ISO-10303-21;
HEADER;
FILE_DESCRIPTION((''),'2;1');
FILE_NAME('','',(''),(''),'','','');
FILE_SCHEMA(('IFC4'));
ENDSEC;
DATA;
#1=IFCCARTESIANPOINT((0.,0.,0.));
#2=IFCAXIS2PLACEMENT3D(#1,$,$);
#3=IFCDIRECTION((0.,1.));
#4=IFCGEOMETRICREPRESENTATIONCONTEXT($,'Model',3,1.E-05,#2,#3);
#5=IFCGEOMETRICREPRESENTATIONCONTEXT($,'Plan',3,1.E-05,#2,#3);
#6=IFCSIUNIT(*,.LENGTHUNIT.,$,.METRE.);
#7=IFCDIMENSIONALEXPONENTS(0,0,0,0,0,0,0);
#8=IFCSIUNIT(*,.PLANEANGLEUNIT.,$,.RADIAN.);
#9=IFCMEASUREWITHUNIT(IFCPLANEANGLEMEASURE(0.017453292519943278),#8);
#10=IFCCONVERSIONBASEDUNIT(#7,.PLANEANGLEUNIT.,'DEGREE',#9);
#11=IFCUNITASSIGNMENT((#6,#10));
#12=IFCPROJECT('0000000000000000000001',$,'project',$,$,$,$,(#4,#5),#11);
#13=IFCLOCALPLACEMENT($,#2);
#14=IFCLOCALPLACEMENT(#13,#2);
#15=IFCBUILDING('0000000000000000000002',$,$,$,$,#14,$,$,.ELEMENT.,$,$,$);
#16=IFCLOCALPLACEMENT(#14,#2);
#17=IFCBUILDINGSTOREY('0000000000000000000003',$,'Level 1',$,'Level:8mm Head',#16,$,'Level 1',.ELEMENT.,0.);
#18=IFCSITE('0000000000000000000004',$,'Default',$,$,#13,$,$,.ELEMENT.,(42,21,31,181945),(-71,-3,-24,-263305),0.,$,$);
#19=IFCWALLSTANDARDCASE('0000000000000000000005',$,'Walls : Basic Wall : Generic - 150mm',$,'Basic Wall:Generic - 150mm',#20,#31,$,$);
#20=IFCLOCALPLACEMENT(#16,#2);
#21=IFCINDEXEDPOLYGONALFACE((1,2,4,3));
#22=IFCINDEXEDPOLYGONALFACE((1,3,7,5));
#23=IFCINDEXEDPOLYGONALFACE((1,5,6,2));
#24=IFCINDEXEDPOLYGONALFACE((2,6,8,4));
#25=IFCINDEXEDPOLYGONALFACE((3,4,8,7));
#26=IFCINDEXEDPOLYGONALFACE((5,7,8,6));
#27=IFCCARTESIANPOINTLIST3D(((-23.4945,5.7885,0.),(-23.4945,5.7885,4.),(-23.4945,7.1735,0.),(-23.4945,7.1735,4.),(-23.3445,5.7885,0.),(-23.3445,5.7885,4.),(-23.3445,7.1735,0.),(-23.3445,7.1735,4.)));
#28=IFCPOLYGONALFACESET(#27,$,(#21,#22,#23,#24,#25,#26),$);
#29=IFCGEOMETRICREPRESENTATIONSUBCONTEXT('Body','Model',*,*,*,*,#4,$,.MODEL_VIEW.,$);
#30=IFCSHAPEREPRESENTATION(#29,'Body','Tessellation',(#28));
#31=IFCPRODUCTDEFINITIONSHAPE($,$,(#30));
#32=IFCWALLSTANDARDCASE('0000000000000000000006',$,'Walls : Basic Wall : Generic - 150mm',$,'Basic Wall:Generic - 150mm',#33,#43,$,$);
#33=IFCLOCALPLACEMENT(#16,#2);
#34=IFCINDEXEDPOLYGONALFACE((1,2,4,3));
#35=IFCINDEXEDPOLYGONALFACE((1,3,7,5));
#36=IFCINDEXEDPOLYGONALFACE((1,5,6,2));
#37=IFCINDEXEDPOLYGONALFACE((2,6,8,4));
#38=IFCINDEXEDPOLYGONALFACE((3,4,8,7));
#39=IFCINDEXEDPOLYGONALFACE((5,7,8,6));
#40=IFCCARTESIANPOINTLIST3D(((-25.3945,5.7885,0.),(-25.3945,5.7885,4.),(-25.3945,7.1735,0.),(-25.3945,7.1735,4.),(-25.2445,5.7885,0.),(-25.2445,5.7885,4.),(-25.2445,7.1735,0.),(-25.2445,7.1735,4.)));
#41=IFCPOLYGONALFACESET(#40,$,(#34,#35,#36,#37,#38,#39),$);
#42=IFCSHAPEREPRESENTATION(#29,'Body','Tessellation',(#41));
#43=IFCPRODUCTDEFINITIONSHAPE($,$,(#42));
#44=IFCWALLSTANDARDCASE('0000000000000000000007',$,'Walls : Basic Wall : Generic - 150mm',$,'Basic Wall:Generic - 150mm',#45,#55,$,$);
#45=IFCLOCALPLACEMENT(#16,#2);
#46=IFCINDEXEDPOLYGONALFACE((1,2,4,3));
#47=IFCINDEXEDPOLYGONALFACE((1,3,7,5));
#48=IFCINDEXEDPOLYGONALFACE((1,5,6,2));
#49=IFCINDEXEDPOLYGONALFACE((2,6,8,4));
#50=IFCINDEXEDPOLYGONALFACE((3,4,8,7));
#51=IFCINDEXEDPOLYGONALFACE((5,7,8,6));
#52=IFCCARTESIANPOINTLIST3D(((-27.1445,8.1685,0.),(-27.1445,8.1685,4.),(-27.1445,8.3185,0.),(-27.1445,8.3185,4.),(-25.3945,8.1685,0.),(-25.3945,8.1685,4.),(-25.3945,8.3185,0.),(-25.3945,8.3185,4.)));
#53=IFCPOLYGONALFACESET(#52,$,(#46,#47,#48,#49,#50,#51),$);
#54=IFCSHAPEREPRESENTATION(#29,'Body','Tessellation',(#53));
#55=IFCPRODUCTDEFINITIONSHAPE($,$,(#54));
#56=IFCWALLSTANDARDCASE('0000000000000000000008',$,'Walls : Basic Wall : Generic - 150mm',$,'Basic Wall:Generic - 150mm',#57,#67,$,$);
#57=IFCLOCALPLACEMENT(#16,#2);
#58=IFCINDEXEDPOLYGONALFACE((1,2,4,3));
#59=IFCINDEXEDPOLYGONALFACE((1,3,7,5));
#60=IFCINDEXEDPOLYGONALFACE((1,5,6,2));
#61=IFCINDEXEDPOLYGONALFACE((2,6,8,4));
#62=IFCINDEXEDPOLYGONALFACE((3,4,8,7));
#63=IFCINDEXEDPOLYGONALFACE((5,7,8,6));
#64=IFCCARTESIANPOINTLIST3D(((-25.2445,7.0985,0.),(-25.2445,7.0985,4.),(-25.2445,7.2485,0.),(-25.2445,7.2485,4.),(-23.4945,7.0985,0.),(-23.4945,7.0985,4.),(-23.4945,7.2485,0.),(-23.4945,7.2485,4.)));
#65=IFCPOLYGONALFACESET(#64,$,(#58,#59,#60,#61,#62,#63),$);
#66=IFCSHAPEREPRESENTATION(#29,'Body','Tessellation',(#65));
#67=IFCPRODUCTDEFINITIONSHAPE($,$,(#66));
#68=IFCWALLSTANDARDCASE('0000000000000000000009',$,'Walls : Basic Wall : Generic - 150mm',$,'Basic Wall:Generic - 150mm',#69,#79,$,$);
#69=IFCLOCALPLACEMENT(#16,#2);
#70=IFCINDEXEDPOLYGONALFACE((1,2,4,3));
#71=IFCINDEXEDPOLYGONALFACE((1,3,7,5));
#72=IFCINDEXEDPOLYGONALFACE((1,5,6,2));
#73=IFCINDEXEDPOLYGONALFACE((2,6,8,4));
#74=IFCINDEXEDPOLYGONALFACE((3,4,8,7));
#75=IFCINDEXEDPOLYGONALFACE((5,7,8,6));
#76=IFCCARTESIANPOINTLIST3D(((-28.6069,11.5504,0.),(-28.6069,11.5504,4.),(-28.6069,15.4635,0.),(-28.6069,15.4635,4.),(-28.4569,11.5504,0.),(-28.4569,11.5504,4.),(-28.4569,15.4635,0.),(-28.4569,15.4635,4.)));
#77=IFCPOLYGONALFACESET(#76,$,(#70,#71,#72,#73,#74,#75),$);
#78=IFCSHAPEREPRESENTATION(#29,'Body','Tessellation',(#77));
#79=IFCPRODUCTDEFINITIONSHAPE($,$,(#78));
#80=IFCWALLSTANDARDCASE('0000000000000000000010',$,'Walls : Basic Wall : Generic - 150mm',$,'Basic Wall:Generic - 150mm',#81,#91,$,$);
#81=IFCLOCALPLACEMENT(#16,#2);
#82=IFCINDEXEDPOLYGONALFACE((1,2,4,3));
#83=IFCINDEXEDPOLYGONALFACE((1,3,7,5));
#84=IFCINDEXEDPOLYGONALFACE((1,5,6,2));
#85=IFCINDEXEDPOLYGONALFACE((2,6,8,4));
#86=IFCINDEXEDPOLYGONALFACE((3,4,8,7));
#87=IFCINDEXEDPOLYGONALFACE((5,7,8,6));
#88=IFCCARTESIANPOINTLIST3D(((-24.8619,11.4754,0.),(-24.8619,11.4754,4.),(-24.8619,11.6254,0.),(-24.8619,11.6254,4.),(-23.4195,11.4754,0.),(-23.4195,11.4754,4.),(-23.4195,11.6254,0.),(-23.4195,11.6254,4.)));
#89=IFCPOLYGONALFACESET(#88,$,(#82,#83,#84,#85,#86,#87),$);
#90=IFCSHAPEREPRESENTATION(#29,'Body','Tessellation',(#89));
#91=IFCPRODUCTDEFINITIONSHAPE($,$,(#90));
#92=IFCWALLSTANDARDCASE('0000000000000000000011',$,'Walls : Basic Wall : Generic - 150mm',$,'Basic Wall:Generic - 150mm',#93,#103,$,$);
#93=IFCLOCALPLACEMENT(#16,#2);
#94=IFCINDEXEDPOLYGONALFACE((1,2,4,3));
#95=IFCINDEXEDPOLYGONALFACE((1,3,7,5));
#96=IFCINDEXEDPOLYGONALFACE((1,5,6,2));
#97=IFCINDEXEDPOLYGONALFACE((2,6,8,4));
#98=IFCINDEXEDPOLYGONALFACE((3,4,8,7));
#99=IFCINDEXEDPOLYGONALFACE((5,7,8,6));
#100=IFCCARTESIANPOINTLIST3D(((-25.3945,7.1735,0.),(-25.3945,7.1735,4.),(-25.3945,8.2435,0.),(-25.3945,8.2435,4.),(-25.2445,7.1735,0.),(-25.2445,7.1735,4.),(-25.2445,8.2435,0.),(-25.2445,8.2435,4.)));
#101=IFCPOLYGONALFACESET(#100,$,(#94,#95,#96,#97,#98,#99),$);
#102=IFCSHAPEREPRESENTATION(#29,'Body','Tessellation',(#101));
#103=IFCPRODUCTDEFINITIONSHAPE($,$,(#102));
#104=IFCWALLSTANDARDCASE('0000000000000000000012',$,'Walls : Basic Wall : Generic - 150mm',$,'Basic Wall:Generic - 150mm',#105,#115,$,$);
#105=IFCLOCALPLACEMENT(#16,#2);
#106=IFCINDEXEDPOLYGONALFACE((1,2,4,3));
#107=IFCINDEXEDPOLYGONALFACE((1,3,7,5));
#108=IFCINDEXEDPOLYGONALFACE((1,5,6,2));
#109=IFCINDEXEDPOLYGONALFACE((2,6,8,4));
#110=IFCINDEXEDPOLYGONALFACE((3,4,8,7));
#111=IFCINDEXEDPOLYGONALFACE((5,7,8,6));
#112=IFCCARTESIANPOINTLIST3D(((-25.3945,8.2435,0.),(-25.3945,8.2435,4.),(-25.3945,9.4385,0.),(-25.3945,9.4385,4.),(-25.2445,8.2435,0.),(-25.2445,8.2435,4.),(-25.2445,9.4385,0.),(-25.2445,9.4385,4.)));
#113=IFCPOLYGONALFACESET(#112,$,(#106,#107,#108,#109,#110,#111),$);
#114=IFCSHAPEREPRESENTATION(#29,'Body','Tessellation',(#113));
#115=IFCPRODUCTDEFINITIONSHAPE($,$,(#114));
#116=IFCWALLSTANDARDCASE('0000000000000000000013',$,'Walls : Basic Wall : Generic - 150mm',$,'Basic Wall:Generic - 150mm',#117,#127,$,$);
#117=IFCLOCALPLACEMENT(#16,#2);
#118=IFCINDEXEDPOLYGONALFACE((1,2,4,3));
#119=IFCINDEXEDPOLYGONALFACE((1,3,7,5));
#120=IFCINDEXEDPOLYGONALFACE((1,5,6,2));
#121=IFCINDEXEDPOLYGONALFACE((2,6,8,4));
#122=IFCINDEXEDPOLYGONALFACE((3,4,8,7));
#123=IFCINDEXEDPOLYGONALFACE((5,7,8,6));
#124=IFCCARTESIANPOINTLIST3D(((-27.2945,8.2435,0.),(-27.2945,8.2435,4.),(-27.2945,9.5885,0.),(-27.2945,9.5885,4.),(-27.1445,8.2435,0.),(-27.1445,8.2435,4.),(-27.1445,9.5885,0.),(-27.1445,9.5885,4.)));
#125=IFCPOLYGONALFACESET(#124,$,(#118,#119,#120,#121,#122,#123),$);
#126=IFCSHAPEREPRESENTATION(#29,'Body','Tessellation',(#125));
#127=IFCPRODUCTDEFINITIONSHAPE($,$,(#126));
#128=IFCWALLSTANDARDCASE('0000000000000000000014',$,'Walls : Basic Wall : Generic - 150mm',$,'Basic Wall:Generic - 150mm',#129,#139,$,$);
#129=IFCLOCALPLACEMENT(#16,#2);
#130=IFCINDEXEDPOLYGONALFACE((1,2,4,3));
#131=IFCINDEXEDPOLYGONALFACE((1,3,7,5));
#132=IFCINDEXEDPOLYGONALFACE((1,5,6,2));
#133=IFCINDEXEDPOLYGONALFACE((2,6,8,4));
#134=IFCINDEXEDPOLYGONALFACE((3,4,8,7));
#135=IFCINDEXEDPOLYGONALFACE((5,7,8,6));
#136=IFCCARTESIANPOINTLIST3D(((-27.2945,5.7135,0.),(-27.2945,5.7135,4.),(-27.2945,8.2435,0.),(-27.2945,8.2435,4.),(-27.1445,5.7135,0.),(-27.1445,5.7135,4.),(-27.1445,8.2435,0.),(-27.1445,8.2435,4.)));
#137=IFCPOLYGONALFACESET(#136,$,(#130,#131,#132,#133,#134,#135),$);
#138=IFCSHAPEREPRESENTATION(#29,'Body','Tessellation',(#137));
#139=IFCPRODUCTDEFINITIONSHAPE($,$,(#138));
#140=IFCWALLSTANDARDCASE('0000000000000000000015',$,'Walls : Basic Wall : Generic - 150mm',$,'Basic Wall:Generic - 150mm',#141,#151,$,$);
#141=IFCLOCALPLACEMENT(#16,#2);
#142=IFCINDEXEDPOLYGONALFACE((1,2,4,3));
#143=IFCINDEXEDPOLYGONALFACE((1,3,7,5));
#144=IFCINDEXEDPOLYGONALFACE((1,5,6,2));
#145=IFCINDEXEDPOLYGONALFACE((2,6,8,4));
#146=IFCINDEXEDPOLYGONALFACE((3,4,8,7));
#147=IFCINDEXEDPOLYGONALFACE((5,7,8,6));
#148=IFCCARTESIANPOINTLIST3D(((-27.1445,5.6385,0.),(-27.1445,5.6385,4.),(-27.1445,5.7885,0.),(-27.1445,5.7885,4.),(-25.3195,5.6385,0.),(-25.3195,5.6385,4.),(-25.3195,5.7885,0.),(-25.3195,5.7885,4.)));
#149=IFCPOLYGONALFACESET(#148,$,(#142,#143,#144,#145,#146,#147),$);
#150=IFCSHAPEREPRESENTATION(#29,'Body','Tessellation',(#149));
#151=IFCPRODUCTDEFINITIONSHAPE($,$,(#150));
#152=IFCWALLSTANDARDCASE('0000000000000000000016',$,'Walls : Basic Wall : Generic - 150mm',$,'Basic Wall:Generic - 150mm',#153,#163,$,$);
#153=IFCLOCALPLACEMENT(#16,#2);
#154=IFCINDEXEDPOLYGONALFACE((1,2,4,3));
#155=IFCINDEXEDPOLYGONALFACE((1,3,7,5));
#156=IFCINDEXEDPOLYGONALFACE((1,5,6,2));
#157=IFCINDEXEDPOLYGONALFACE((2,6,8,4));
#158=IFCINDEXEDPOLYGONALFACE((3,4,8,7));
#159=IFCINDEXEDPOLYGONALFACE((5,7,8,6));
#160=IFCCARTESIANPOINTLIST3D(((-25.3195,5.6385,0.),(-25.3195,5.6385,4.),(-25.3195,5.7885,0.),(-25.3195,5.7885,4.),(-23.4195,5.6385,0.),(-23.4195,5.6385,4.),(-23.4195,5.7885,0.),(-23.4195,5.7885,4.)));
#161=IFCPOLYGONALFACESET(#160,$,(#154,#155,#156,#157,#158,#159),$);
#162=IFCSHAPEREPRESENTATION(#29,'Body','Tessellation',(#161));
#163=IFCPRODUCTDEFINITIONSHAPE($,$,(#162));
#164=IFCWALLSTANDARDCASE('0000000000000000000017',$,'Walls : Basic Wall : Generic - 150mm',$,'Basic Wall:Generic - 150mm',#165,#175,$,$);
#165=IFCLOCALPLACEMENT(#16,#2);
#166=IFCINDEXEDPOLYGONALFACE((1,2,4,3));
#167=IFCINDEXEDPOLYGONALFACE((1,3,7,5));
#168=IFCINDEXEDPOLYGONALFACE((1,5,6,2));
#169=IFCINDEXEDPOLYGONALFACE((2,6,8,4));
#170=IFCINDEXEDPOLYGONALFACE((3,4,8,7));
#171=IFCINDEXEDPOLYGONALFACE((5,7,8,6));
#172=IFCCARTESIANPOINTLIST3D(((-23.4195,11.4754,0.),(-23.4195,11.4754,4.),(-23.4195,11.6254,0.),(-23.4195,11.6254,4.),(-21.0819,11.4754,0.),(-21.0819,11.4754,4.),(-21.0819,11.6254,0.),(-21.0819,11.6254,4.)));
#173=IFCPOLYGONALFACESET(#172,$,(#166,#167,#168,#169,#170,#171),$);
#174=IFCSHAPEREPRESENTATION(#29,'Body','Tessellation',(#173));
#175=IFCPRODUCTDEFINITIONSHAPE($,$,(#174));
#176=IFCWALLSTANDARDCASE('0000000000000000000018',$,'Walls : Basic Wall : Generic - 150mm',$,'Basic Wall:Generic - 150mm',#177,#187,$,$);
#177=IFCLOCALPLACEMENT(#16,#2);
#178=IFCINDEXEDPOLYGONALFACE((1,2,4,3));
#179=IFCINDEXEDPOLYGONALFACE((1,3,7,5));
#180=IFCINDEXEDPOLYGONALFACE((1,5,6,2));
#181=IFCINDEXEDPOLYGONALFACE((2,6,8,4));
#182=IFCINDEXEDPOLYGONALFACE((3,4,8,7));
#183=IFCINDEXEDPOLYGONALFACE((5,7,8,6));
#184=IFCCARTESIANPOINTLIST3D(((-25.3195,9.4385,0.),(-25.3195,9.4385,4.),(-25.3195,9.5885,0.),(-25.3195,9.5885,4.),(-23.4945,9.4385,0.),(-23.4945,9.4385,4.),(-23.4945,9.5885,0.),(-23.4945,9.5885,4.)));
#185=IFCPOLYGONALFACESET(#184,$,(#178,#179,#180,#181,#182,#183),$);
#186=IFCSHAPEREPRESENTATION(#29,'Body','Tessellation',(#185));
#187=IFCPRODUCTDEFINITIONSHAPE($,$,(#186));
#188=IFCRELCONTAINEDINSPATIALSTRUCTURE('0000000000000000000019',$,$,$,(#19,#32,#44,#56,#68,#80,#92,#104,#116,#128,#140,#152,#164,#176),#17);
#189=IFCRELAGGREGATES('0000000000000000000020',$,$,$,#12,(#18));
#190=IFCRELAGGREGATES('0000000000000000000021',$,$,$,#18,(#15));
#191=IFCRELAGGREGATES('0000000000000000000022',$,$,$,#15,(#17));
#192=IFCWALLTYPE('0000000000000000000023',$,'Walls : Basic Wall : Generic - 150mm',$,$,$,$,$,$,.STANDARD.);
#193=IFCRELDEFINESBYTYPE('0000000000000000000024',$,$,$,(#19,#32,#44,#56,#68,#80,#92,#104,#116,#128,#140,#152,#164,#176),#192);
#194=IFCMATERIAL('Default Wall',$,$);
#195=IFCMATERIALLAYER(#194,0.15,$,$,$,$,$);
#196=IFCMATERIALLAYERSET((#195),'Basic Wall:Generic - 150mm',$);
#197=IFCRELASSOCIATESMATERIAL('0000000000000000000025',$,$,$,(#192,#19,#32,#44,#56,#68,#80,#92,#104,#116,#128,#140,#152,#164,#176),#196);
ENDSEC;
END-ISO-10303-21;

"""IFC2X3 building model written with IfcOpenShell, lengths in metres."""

from ifc_helpers import new_model, entity, si_unit, converted_unit, direction, frame, frame_2d, origin, place, context, subcontext, project, spatial, rectangle, extrude, material, layer, layer_set, layer_usage, type_object, element, save


model = new_model("IFC2X3")

# Units and contexts
model_context = context("Model", 3, precision=1e-05, world=origin(), true_north=direction((0.0, 1.0)))
plan_context = context("Plan", 3, precision=1e-05, world=origin(), true_north=direction((0.0, 1.0)))
body_context = subcontext(model_context, "Body", "Model", "MODEL_VIEW")
ifc_project = project(units=[si_unit("LENGTHUNIT", "METRE"), converted_unit("PLANEANGLEUNIT", "DEGREE", entity("IfcPlaneAngleMeasure", 0.017453292519943278), si_unit("PLANEANGLEUNIT", "RADIAN"), dimensions=[0, 0, 0, 0, 0, 0, 0])], contexts=[model_context, plan_context])

# Site, building, storey
site_placement = place(None, origin())
site = spatial("IfcSite", under=ifc_project, at=site_placement, Name="Default", CompositionType="ELEMENT", RefLatitude=(42, 21, 31, 181945), RefLongitude=(-71, -3, -24, -263305), RefElevation=0.0)
building_placement = place(site_placement, origin())
building = spatial("IfcBuilding", under=site, at=building_placement, CompositionType="ELEMENT")
storey_placement = place(building_placement, origin())
storey = spatial("IfcBuildingStorey", under=building, at=storey_placement, Name="Level 1", ObjectType="Level:8mm Head", LongName="Level 1", CompositionType="ELEMENT", Elevation=0.0)

# Walls
ifc_material = material(Name="Default Wall")
ifc_layer_1 = layer(ifc_material, 0.15)
ifc_layer_set_1 = layer_set([ifc_layer_1], Name="Basic Wall:Generic - 150mm")
ifc_layer_usage_1 = layer_usage(ifc_layer_set_1, "AXIS2", "NEGATIVE", 0.075)
wall_type_1 = type_object("IfcWallType", Name="Walls : Basic Wall : Generic - 150mm", PredefinedType="STANDARD", material=ifc_layer_set_1)
wall_1_placement = place(storey_placement, frame((-23.4195, 5.7885, 0.0), z_axis=(0.0, 0.0, 1.0), x_axis=(0.0, 1.0, 0.0)))
element("IfcWallStandardCase", 1, at=wall_1_placement, inside=storey, type_object=wall_type_1, material=ifc_layer_usage_1, Name="Walls : Basic Wall : Generic - 150mm", ObjectType="Basic Wall:Generic - 150mm", context=body_context, shape_type="SweptSolid", body=[
    extrude(rectangle(XDim=1.385, YDim=0.15, at=frame_2d((0.6925, 0.0), x_axis=(-1.0, 0.0))), origin(), (0.0, 0.0, 1.0), 4.0),
])
wall_2_placement = place(storey_placement, frame((-25.3195, 5.7885, 0.0), z_axis=(0.0, 0.0, 1.0), x_axis=(0.0, 1.0, 0.0)))
element("IfcWallStandardCase", 2, at=wall_2_placement, inside=storey, type_object=wall_type_1, material=ifc_layer_usage_1, Name="Walls : Basic Wall : Generic - 150mm", ObjectType="Basic Wall:Generic - 150mm", context=body_context, shape_type="SweptSolid", body=[
    extrude(rectangle(XDim=1.385, YDim=0.15, at=frame_2d((0.6925, 0.0), x_axis=(-1.0, 0.0))), origin(), (0.0, 0.0, 1.0), 4.0),
])
wall_3_placement = place(storey_placement, frame((-25.3945, 8.2435, 0.0), z_axis=(0.0, 0.0, 1.0), x_axis=(-1.0, 0.0, 0.0)))
element("IfcWallStandardCase", 3, at=wall_3_placement, inside=storey, type_object=wall_type_1, material=ifc_layer_usage_1, Name="Walls : Basic Wall : Generic - 150mm", ObjectType="Basic Wall:Generic - 150mm", context=body_context, shape_type="SweptSolid", body=[
    extrude(rectangle(XDim=1.75, YDim=0.15, at=frame_2d((0.875, 0.0), x_axis=(-1.0, 0.0))), origin(), (0.0, 0.0, 1.0), 4.0),
])
wall_4_placement = place(storey_placement, frame((-25.2445, 7.1735, 0.0)))
element("IfcWallStandardCase", 4, at=wall_4_placement, inside=storey, type_object=wall_type_1, material=ifc_layer_usage_1, Name="Walls : Basic Wall : Generic - 150mm", ObjectType="Basic Wall:Generic - 150mm", context=body_context, shape_type="SweptSolid", body=[
    extrude(rectangle(XDim=1.75, YDim=0.15, at=frame_2d((0.875, 0.0), x_axis=(-1.0, 0.0))), origin(), (0.0, 0.0, 1.0), 4.0),
])
wall_5_placement = place(storey_placement, frame((-28.5319, 11.5504, 0.0), z_axis=(0.0, 0.0, 1.0), x_axis=(0.0, 1.0, 0.0)))
element("IfcWallStandardCase", 5, at=wall_5_placement, inside=storey, type_object=wall_type_1, material=ifc_layer_usage_1, Name="Walls : Basic Wall : Generic - 150mm", ObjectType="Basic Wall:Generic - 150mm", context=body_context, shape_type="SweptSolid", body=[
    extrude(rectangle(XDim=3.9131, YDim=0.15, at=frame_2d((1.9565, 0.0), x_axis=(-1.0, 0.0))), origin(), (0.0, 0.0, 1.0), 4.0),
])
wall_6_placement = place(storey_placement, frame((-24.8619, 11.5504, 0.0)))
element("IfcWallStandardCase", 6, at=wall_6_placement, inside=storey, type_object=wall_type_1, material=ifc_layer_usage_1, Name="Walls : Basic Wall : Generic - 150mm", ObjectType="Basic Wall:Generic - 150mm", context=body_context, shape_type="SweptSolid", body=[
    extrude(rectangle(XDim=1.4424, YDim=0.15, at=frame_2d((0.7212, 0.0), x_axis=(-1.0, 0.0))), origin(), (0.0, 0.0, 1.0), 4.0),
])
wall_7_placement = place(storey_placement, frame((-25.3195, 7.1735, 0.0), z_axis=(0.0, 0.0, 1.0), x_axis=(0.0, 1.0, 0.0)))
element("IfcWallStandardCase", 7, at=wall_7_placement, inside=storey, type_object=wall_type_1, material=ifc_layer_usage_1, Name="Walls : Basic Wall : Generic - 150mm", ObjectType="Basic Wall:Generic - 150mm", context=body_context, shape_type="SweptSolid", body=[
    extrude(rectangle(XDim=1.07, YDim=0.15, at=frame_2d((0.535, 0.0), x_axis=(-1.0, 0.0))), origin(), (0.0, 0.0, 1.0), 4.0),
])
wall_8_placement = place(storey_placement, frame((-25.3195, 8.2435, 0.0), z_axis=(0.0, 0.0, 1.0), x_axis=(0.0, 1.0, 0.0)))
element("IfcWallStandardCase", 8, at=wall_8_placement, inside=storey, type_object=wall_type_1, material=ifc_layer_usage_1, Name="Walls : Basic Wall : Generic - 150mm", ObjectType="Basic Wall:Generic - 150mm", context=body_context, shape_type="SweptSolid", body=[
    extrude(rectangle(XDim=1.195, YDim=0.15, at=frame_2d((0.5975, 0.0), x_axis=(-1.0, 0.0))), origin(), (0.0, 0.0, 1.0), 4.0),
])
wall_9_placement = place(storey_placement, frame((-27.2195, 8.2435, 0.0), z_axis=(0.0, 0.0, 1.0), x_axis=(0.0, 1.0, 0.0)))
element("IfcWallStandardCase", 9, at=wall_9_placement, inside=storey, type_object=wall_type_1, material=ifc_layer_usage_1, Name="Walls : Basic Wall : Generic - 150mm", ObjectType="Basic Wall:Generic - 150mm", context=body_context, shape_type="SweptSolid", body=[
    extrude(rectangle(XDim=1.345, YDim=0.15, at=frame_2d((0.6725, 0.0), x_axis=(-1.0, 0.0))), origin(), (0.0, 0.0, 1.0), 4.0),
])
wall_10_placement = place(storey_placement, frame((-27.2195, 5.7135, 0.0), z_axis=(0.0, 0.0, 1.0), x_axis=(0.0, 1.0, 0.0)))
element("IfcWallStandardCase", 10, at=wall_10_placement, inside=storey, type_object=wall_type_1, material=ifc_layer_usage_1, Name="Walls : Basic Wall : Generic - 150mm", ObjectType="Basic Wall:Generic - 150mm", context=body_context, shape_type="SweptSolid", body=[
    extrude(rectangle(XDim=2.53, YDim=0.15, at=frame_2d((1.265, 0.0), x_axis=(-1.0, 0.0))), origin(), (0.0, 0.0, 1.0), 4.0),
])
wall_11_placement = place(storey_placement, frame((-25.3195, 5.7135, 0.0), z_axis=(0.0, 0.0, 1.0), x_axis=(-1.0, 0.0, 0.0)))
element("IfcWallStandardCase", 11, at=wall_11_placement, inside=storey, type_object=wall_type_1, material=ifc_layer_usage_1, Name="Walls : Basic Wall : Generic - 150mm", ObjectType="Basic Wall:Generic - 150mm", context=body_context, shape_type="SweptSolid", body=[
    extrude(rectangle(XDim=1.825, YDim=0.15, at=frame_2d((0.9125, 0.0), x_axis=(-1.0, 0.0))), origin(), (0.0, 0.0, 1.0), 4.0),
])
wall_12_placement = place(storey_placement, frame((-23.4195, 5.7135, 0.0), z_axis=(0.0, 0.0, 1.0), x_axis=(-1.0, 0.0, 0.0)))
element("IfcWallStandardCase", 12, at=wall_12_placement, inside=storey, type_object=wall_type_1, material=ifc_layer_usage_1, Name="Walls : Basic Wall : Generic - 150mm", ObjectType="Basic Wall:Generic - 150mm", context=body_context, shape_type="SweptSolid", body=[
    extrude(rectangle(XDim=1.9, YDim=0.15, at=frame_2d((0.95, 0.0), x_axis=(-1.0, 0.0))), origin(), (0.0, 0.0, 1.0), 4.0),
])
wall_13_placement = place(storey_placement, frame((-23.4195, 11.5504, 0.0)))
element("IfcWallStandardCase", 13, at=wall_13_placement, inside=storey, type_object=wall_type_1, material=ifc_layer_usage_1, Name="Walls : Basic Wall : Generic - 150mm", ObjectType="Basic Wall:Generic - 150mm", context=body_context, shape_type="SweptSolid", body=[
    extrude(rectangle(XDim=2.3376, YDim=0.15, at=frame_2d((1.1688, 0.0), x_axis=(-1.0, 0.0))), origin(), (0.0, 0.0, 1.0), 4.0),
])
wall_14_placement = place(storey_placement, frame((-25.3195, 9.5135, 0.0)))
element("IfcWallStandardCase", 14, at=wall_14_placement, inside=storey, type_object=wall_type_1, material=ifc_layer_usage_1, Name="Walls : Basic Wall : Generic - 150mm", ObjectType="Basic Wall:Generic - 150mm", context=body_context, shape_type="SweptSolid", body=[
    extrude(rectangle(XDim=1.825, YDim=0.15, at=frame_2d((0.9125, 0.0), x_axis=(-1.0, 0.0))), origin(), (0.0, 0.0, 1.0), 4.0),
])

save(model, "model.ifc")
